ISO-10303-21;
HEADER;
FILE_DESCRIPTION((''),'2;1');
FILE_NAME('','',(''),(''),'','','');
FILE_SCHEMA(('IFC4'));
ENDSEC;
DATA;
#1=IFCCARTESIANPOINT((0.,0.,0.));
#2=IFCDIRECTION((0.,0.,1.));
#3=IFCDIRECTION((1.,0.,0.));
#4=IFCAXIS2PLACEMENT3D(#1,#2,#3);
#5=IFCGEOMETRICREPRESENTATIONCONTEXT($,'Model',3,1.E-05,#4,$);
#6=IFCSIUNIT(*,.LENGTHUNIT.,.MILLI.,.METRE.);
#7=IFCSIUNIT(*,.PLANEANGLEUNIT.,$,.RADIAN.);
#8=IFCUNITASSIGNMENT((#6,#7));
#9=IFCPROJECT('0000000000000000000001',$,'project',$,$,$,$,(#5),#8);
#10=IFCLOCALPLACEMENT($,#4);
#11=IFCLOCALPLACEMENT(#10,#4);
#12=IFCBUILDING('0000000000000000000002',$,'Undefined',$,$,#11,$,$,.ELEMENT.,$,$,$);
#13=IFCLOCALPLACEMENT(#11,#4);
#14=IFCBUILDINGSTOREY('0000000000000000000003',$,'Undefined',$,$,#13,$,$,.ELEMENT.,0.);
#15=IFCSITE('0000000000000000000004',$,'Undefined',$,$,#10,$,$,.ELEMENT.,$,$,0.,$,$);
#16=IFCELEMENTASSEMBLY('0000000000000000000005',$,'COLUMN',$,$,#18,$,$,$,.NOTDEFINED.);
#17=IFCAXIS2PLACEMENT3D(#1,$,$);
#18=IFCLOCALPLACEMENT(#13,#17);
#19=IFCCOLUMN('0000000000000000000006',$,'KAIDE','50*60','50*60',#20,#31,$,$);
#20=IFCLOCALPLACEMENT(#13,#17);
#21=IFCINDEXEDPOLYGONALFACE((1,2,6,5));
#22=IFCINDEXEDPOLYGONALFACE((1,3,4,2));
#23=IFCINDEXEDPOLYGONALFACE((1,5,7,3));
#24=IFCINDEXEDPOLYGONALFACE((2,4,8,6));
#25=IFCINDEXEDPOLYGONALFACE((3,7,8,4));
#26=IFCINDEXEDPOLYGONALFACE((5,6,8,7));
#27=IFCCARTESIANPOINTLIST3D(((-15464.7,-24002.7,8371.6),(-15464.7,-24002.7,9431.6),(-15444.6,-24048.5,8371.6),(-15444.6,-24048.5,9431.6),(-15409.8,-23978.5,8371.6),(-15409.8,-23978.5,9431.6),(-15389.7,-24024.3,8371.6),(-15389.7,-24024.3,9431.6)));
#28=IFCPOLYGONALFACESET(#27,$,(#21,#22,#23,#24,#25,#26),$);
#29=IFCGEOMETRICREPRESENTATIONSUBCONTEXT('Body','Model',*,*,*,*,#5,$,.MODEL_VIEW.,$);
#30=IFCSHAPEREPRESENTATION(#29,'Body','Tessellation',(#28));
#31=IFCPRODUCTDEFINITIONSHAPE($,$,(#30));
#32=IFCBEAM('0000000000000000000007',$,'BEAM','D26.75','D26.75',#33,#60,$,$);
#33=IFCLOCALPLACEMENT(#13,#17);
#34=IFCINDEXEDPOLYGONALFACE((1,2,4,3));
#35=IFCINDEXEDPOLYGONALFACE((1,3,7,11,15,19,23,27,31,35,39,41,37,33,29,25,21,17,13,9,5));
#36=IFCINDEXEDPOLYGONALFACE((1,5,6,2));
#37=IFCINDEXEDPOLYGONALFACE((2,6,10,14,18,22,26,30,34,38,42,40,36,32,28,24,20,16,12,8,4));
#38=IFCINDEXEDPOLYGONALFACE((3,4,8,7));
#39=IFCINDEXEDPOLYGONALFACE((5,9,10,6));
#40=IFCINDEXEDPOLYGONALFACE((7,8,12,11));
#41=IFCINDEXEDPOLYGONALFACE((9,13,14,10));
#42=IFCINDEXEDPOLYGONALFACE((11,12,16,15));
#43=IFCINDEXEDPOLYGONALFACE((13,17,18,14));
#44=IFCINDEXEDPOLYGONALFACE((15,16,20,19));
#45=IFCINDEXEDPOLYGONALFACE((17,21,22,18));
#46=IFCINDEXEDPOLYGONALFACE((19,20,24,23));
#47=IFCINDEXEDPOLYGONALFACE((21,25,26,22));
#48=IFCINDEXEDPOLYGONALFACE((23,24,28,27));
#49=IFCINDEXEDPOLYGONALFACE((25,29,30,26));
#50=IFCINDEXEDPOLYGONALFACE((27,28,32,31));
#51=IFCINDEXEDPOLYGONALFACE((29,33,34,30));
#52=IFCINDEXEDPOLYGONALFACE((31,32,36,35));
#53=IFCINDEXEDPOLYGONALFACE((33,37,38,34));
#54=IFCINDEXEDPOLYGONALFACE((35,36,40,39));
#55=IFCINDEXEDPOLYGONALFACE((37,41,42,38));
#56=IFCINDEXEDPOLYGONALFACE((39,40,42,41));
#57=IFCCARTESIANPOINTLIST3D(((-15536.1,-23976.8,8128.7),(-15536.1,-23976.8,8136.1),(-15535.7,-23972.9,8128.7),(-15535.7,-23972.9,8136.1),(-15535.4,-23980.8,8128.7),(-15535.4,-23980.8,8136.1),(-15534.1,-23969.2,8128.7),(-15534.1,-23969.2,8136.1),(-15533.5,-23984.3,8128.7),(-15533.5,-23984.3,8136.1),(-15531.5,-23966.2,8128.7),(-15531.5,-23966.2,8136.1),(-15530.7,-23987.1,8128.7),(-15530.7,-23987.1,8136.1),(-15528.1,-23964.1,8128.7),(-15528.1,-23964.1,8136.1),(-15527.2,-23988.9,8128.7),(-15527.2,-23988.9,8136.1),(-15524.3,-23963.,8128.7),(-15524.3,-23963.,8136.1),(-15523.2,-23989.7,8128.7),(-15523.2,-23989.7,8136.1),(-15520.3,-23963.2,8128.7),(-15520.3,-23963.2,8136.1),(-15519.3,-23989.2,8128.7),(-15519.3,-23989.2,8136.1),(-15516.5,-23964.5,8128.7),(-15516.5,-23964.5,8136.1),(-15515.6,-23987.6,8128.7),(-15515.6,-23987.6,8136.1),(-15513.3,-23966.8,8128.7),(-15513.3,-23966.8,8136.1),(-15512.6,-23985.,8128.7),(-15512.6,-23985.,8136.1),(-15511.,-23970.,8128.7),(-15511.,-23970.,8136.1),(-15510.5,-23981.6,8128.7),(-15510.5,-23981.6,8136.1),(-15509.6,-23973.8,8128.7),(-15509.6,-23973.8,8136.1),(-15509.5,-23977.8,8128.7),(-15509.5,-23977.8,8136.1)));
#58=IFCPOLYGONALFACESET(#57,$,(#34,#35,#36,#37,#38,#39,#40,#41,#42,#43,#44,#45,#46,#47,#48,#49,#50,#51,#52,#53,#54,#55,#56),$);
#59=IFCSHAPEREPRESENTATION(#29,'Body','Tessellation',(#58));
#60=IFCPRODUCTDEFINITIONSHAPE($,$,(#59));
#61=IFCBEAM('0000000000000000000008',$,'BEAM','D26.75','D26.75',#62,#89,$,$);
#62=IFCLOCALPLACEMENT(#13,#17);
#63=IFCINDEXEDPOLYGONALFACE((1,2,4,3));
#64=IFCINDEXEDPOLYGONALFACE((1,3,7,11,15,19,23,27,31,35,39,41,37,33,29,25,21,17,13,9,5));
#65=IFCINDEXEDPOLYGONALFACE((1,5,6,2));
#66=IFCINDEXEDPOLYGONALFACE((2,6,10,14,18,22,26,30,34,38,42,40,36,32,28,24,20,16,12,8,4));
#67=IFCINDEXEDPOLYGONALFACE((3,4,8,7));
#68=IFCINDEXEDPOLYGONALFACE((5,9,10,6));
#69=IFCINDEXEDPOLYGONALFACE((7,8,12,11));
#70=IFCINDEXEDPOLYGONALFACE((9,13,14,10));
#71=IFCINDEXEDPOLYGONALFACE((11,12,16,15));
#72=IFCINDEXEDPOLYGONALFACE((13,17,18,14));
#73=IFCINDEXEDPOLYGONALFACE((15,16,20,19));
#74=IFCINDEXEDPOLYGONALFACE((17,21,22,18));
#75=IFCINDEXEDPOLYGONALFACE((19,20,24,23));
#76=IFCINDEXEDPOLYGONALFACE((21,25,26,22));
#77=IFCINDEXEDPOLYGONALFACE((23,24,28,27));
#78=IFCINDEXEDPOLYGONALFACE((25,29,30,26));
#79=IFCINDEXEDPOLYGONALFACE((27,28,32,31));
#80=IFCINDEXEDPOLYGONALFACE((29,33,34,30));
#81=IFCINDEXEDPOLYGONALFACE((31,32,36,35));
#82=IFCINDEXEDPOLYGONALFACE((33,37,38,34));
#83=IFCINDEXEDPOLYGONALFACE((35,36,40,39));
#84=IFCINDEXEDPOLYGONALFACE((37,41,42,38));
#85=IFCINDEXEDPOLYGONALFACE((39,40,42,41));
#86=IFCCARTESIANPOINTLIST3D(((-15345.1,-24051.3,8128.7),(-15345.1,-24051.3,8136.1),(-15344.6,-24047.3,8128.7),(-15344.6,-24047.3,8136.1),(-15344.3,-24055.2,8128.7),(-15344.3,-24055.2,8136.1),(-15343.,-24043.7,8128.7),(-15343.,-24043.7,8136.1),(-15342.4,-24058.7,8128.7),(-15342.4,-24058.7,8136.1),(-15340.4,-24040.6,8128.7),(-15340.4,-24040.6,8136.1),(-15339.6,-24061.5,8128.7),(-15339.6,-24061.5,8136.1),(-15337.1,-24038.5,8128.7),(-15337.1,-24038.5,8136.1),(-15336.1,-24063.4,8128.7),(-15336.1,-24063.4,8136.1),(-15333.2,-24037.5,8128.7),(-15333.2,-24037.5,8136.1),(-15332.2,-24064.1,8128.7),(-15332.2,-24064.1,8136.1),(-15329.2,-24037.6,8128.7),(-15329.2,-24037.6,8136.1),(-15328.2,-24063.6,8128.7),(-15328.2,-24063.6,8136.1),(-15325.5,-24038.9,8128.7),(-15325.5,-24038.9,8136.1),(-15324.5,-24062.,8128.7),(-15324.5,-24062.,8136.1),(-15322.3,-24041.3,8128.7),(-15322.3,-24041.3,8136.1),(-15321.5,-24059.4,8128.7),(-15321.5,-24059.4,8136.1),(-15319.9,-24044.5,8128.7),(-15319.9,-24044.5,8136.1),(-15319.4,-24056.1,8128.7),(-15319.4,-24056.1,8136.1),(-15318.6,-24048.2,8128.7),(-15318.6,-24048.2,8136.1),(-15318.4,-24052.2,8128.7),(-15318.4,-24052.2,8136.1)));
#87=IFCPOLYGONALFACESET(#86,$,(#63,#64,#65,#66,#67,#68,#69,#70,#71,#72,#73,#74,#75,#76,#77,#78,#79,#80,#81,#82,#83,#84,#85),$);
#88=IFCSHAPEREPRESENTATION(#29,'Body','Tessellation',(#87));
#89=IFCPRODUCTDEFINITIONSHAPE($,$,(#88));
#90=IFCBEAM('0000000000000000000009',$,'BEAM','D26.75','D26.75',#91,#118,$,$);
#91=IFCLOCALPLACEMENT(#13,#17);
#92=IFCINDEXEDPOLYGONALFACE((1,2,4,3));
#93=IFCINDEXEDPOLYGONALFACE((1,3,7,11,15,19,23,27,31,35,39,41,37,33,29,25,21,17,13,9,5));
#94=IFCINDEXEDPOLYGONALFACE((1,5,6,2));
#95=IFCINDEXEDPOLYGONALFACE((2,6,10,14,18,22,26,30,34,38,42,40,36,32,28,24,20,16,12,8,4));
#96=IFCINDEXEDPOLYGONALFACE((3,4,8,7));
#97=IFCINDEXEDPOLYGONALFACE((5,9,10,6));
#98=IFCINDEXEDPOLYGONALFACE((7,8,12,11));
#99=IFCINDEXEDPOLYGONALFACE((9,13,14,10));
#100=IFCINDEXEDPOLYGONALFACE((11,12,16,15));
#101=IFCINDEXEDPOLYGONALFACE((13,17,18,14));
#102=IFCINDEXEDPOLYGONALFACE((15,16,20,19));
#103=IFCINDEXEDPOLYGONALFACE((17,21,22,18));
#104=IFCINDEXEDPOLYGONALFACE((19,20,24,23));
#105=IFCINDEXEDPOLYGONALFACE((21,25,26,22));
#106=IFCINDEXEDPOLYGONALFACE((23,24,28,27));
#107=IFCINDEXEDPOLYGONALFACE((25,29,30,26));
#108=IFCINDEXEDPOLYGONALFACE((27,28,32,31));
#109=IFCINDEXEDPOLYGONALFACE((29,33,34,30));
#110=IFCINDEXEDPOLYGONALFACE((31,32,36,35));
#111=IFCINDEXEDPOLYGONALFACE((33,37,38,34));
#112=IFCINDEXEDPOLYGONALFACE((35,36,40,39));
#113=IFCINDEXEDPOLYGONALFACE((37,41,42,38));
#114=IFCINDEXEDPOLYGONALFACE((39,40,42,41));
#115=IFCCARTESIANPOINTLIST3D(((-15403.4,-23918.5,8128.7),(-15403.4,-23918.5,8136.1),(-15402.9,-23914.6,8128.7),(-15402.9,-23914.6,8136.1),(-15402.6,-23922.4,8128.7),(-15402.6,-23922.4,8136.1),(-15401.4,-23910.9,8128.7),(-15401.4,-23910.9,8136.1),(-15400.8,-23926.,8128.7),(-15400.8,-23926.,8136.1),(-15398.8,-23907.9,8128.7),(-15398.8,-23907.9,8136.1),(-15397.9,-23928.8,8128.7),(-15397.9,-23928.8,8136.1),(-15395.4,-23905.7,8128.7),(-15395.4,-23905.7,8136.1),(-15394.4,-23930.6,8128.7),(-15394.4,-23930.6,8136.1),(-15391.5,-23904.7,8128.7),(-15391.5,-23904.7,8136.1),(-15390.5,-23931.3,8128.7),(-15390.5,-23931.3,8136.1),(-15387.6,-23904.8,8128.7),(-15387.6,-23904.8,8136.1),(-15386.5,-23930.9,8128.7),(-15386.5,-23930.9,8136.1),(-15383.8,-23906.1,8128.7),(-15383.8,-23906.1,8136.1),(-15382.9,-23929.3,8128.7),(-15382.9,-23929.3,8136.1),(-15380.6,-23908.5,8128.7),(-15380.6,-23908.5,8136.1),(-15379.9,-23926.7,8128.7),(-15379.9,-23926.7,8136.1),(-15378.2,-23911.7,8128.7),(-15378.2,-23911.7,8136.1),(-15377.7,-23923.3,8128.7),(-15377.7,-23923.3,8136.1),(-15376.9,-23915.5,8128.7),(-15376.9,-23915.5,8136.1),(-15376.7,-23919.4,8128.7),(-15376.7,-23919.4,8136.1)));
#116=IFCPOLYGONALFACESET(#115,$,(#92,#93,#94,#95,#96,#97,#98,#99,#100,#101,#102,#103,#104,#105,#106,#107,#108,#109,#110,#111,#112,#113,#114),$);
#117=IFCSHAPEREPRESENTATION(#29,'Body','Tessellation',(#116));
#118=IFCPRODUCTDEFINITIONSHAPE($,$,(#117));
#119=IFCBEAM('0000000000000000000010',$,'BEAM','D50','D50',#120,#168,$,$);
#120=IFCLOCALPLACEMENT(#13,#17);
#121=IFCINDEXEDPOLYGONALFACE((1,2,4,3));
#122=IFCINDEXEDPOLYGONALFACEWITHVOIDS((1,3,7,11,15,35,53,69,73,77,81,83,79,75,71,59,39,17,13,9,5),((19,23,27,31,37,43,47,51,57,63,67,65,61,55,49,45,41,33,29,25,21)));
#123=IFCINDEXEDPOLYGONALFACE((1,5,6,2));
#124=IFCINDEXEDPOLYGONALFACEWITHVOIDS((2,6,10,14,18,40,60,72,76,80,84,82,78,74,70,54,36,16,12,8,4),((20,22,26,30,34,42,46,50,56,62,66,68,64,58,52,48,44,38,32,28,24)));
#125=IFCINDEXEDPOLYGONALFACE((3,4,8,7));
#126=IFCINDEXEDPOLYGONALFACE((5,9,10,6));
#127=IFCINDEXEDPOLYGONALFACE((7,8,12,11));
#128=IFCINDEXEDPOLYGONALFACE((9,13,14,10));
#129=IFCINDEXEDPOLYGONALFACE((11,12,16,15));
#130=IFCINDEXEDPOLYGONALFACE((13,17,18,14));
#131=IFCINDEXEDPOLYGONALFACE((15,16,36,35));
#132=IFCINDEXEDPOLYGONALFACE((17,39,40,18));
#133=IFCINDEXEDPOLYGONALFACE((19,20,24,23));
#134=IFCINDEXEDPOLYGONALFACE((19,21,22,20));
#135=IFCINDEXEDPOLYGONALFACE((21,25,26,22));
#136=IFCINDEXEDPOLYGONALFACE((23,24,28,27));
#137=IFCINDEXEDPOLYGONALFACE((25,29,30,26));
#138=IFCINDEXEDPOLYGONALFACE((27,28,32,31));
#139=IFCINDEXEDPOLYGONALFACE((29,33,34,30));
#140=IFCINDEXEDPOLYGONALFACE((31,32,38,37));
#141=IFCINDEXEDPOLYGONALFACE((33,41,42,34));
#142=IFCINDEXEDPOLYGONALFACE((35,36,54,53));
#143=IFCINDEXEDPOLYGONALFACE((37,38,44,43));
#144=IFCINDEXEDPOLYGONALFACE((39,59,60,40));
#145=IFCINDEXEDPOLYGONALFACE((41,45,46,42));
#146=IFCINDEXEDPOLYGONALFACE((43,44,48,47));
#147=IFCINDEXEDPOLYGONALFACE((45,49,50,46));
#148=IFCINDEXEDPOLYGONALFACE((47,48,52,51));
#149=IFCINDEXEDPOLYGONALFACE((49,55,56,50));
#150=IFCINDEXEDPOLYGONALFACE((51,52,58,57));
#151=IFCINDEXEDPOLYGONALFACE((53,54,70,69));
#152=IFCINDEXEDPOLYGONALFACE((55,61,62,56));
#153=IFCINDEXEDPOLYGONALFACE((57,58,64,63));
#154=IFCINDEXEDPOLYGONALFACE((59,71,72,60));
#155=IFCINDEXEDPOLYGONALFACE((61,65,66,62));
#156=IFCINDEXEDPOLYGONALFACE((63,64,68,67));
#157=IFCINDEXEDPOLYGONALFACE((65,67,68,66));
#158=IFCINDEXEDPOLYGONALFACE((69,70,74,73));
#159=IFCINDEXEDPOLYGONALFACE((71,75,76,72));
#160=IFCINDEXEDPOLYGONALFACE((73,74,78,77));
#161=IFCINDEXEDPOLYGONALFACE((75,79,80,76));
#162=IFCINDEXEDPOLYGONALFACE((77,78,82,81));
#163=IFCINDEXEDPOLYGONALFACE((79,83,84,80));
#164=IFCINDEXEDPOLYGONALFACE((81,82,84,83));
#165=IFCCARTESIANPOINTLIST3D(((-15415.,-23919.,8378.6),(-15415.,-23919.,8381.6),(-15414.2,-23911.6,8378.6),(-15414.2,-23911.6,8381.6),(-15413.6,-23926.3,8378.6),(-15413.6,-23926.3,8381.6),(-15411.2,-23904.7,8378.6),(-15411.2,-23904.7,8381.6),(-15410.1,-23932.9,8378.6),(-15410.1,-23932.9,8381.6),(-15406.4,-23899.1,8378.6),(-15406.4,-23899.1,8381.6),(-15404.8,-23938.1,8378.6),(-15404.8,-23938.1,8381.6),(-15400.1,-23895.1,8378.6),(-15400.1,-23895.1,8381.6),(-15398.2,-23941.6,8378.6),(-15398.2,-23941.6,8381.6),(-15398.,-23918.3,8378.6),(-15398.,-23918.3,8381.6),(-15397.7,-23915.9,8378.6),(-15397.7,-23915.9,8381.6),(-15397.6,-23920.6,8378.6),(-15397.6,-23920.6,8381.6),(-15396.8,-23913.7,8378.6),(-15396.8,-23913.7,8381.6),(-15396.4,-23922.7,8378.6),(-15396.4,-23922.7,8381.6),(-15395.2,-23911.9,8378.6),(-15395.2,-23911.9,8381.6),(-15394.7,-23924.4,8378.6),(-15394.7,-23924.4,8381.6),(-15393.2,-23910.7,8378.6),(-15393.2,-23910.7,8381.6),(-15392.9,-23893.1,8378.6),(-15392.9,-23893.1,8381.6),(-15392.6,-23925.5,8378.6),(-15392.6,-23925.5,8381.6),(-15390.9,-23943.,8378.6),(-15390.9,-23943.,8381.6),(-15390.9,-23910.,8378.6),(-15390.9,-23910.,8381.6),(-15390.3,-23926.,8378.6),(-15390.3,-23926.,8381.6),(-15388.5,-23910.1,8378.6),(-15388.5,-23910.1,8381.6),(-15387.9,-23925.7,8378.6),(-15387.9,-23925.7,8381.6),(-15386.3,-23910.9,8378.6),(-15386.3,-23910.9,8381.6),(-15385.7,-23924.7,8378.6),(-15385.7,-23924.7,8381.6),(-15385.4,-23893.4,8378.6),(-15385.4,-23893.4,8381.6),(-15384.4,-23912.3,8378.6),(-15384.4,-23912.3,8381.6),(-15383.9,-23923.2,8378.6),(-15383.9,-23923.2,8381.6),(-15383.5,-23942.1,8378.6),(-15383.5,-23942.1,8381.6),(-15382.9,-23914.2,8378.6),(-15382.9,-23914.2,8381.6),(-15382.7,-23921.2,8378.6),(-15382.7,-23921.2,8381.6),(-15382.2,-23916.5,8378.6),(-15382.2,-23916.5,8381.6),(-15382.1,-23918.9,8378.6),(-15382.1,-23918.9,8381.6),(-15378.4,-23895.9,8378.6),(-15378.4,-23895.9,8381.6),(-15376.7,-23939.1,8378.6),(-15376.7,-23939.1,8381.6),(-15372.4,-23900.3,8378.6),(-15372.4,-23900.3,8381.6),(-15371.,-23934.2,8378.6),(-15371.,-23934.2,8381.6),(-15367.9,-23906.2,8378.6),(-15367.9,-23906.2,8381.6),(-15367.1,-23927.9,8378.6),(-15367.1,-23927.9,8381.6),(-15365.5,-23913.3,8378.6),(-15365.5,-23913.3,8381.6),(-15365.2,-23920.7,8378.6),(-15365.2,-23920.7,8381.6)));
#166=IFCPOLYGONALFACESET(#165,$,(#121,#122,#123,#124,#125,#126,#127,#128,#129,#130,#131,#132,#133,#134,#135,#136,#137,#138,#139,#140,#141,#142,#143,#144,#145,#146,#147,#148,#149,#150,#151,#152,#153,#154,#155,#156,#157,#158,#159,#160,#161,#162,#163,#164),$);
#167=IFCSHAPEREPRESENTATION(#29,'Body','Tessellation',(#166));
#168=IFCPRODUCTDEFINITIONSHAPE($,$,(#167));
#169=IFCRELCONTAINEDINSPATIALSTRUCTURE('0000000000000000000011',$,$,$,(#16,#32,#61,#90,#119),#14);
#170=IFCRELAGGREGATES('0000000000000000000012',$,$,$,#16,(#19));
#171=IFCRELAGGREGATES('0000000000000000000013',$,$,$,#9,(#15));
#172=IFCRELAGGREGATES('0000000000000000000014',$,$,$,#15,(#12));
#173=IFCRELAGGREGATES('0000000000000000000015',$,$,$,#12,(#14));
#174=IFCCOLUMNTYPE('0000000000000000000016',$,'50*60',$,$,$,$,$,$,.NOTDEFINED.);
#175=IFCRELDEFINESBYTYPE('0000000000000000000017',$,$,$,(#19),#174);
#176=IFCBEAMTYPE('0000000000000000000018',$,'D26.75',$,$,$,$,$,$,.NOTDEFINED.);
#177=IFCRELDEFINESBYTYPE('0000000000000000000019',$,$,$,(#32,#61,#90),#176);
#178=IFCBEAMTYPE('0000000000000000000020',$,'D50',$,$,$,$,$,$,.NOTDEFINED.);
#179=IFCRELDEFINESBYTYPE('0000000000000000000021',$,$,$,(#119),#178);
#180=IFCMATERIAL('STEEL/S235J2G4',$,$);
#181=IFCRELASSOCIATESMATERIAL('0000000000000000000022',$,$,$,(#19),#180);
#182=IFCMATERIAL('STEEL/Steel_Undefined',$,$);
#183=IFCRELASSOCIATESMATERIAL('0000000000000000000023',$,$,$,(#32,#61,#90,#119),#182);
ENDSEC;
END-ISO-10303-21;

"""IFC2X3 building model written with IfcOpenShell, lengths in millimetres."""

from ifc_helpers import new_model, si_unit, frame, origin_with_axes, origin_2d_with_axis, place, context, subcontext, project, spatial, rectangle, circle, extrude, material, type_object, element, aggregate, save


model = new_model("IFC2X3")

# Units and contexts
model_context = context("Model", 3, precision=1e-05, world=origin_with_axes())
body_context = subcontext(model_context, "Body", "Model", "MODEL_VIEW")
ifc_project = project(units=[si_unit("LENGTHUNIT", "METRE", prefix="MILLI"), si_unit("PLANEANGLEUNIT", "RADIAN")], contexts=[model_context])

# Site, building, storey
site_placement = place(None, origin_with_axes())
site = spatial("IfcSite", under=ifc_project, at=site_placement, Name="Undefined", CompositionType="ELEMENT", RefElevation=0.0)
building_placement = place(site_placement, origin_with_axes())
building = spatial("IfcBuilding", under=site, at=building_placement, Name="Undefined", CompositionType="ELEMENT")
storey_placement = place(building_placement, origin_with_axes())
storey = spatial("IfcBuildingStorey", under=building, at=storey_placement, Name="Undefined", CompositionType="ELEMENT", Elevation=0.0)

# Element assembly, column
assembly_placement = place(storey_placement, frame((-15427.2, -24013.5, 8371.6), z_axis=(-0.402199, 0.915552, 0.0), x_axis=(0.0, 0.0, 1.0)))
assembly = element("IfcElementAssembly", 1, at=assembly_placement, inside=storey, Name="COLUMN", PredefinedType="NOTDEFINED")
ifc_material_1 = material(Name="STEEL/S235J2G4")
column_type = type_object("IfcColumnType", Name="50*60", PredefinedType="NOTDEFINED")
column_placement = place(storey_placement, frame((-15427.2, -24013.5, 8371.6), z_axis=(0.0, 0.0, 1.0), x_axis=(1.0, 0.0, 0.0)))
column = element("IfcColumn", 2, at=column_placement, type_object=column_type, material=ifc_material_1, Name="KAIDE", Description="50*60", ObjectType="50*60", context=body_context, shape_type="SweptSolid", body=[
    extrude(rectangle(XDim=60.0, YDim=50.0, at=origin_2d_with_axis()), frame((0.0, 0.0, 1060.0), z_axis=(0.0, 0.0, -1.0), x_axis=(-0.915552, -0.402199, 0.0)), (0.0, 0.0, 1.0), 1060.0),
])
aggregate(assembly, [column])

# Shared definitions
ifc_material_2 = material(Name="STEEL/Steel_Undefined")
beam_type_1 = type_object("IfcBeamType", Name="D26.75", PredefinedType="NOTDEFINED")

# Beams
for number, where, z_axis, x_axis, name in (
    (3, (-15522.8, -23976.3, 8136.1), (-0.915552, -0.4022, 0.0), (0.0, 0.0, -1.0), "BEAM"),
    (4, (-15331.7, -24050.7, 8136.1), (-0.915552, -0.4022, 0.0), (0.0, 0.0, -1.0), "BEAM"),
):
    element("IfcBeam", number, at=place(storey_placement, frame(where, z_axis=z_axis, x_axis=x_axis)), inside=storey, type_object=beam_type_1, material=ifc_material_2, Name=name, Description="D26.75", ObjectType="D26.75", context=body_context, shape_type="SweptSolid", body=[
        extrude(circle(Radius=13.4, at=origin_2d_with_axis()), frame((7.4, 0.0, 0.0), z_axis=(-1.0, 0.0, 0.0), x_axis=(0.0, -1.0, 0.0)), (0.0, 0.0, 1.0), 7.4),
    ])

# Beam
beam_1_placement = place(storey_placement, frame((-15390.0, -23918.0, 8136.1), z_axis=(-0.915552, -0.4022, 0.0), x_axis=(0.0, 0.0, -1.0)))
element("IfcBeam", 5, at=beam_1_placement, inside=storey, type_object=beam_type_1, material=ifc_material_2, Name="BEAM", Description="D26.75", ObjectType="D26.75", context=body_context, shape_type="SweptSolid", body=[
    extrude(circle(Radius=13.4, at=origin_2d_with_axis()), frame((7.4, 0.0, 0.0), z_axis=(-1.0, 0.0, 0.0), x_axis=(0.0, -1.0, 0.0)), (0.0, 0.0, 1.0), 7.4),
])

# Beam, opening
beam_type_2 = type_object("IfcBeamType", Name="D50", PredefinedType="NOTDEFINED")
beam_2_placement = place(storey_placement, frame((-15390.0, -23918.0, 8381.6), z_axis=(-0.915552, -0.4022, 0.0), x_axis=(0.0, 0.0, -1.0)))
beam_2 = element("IfcBeam", 6, at=beam_2_placement, inside=storey, type_object=beam_type_2, material=ifc_material_2, Name="BEAM", Description="D50", ObjectType="D50", context=body_context, shape_type="SweptSolid", body=[
    extrude(circle(Radius=25.0, at=origin_2d_with_axis()), frame((3.0, 0.0, 0.0), z_axis=(-1.0, 0.0, 0.0), x_axis=(0.0, -1.0, 0.0)), (0.0, 0.0, 1.0), 3.0),
])
opening_1_placement = place(storey_placement, frame((-15390.0, -23918.0, 8381.6), z_axis=(-0.915552, -0.4022, 0.0), x_axis=(0.0, 0.0, -1.0)))
element("IfcOpeningElement", 7, at=opening_1_placement, cuts=beam_2, ObjectType="Recess", context=body_context, shape_type="SweptSolid", body=[
    extrude(circle(Radius=8.0, at=origin_2d_with_axis()), frame((245.5, 0.0, 0.0), z_axis=(-1.0, 0.0, 0.0), x_axis=(0.0, -1.0, 0.0)), (0.0, 0.0, 1.0), 292.6),
])

save(model, "model.ifc")
